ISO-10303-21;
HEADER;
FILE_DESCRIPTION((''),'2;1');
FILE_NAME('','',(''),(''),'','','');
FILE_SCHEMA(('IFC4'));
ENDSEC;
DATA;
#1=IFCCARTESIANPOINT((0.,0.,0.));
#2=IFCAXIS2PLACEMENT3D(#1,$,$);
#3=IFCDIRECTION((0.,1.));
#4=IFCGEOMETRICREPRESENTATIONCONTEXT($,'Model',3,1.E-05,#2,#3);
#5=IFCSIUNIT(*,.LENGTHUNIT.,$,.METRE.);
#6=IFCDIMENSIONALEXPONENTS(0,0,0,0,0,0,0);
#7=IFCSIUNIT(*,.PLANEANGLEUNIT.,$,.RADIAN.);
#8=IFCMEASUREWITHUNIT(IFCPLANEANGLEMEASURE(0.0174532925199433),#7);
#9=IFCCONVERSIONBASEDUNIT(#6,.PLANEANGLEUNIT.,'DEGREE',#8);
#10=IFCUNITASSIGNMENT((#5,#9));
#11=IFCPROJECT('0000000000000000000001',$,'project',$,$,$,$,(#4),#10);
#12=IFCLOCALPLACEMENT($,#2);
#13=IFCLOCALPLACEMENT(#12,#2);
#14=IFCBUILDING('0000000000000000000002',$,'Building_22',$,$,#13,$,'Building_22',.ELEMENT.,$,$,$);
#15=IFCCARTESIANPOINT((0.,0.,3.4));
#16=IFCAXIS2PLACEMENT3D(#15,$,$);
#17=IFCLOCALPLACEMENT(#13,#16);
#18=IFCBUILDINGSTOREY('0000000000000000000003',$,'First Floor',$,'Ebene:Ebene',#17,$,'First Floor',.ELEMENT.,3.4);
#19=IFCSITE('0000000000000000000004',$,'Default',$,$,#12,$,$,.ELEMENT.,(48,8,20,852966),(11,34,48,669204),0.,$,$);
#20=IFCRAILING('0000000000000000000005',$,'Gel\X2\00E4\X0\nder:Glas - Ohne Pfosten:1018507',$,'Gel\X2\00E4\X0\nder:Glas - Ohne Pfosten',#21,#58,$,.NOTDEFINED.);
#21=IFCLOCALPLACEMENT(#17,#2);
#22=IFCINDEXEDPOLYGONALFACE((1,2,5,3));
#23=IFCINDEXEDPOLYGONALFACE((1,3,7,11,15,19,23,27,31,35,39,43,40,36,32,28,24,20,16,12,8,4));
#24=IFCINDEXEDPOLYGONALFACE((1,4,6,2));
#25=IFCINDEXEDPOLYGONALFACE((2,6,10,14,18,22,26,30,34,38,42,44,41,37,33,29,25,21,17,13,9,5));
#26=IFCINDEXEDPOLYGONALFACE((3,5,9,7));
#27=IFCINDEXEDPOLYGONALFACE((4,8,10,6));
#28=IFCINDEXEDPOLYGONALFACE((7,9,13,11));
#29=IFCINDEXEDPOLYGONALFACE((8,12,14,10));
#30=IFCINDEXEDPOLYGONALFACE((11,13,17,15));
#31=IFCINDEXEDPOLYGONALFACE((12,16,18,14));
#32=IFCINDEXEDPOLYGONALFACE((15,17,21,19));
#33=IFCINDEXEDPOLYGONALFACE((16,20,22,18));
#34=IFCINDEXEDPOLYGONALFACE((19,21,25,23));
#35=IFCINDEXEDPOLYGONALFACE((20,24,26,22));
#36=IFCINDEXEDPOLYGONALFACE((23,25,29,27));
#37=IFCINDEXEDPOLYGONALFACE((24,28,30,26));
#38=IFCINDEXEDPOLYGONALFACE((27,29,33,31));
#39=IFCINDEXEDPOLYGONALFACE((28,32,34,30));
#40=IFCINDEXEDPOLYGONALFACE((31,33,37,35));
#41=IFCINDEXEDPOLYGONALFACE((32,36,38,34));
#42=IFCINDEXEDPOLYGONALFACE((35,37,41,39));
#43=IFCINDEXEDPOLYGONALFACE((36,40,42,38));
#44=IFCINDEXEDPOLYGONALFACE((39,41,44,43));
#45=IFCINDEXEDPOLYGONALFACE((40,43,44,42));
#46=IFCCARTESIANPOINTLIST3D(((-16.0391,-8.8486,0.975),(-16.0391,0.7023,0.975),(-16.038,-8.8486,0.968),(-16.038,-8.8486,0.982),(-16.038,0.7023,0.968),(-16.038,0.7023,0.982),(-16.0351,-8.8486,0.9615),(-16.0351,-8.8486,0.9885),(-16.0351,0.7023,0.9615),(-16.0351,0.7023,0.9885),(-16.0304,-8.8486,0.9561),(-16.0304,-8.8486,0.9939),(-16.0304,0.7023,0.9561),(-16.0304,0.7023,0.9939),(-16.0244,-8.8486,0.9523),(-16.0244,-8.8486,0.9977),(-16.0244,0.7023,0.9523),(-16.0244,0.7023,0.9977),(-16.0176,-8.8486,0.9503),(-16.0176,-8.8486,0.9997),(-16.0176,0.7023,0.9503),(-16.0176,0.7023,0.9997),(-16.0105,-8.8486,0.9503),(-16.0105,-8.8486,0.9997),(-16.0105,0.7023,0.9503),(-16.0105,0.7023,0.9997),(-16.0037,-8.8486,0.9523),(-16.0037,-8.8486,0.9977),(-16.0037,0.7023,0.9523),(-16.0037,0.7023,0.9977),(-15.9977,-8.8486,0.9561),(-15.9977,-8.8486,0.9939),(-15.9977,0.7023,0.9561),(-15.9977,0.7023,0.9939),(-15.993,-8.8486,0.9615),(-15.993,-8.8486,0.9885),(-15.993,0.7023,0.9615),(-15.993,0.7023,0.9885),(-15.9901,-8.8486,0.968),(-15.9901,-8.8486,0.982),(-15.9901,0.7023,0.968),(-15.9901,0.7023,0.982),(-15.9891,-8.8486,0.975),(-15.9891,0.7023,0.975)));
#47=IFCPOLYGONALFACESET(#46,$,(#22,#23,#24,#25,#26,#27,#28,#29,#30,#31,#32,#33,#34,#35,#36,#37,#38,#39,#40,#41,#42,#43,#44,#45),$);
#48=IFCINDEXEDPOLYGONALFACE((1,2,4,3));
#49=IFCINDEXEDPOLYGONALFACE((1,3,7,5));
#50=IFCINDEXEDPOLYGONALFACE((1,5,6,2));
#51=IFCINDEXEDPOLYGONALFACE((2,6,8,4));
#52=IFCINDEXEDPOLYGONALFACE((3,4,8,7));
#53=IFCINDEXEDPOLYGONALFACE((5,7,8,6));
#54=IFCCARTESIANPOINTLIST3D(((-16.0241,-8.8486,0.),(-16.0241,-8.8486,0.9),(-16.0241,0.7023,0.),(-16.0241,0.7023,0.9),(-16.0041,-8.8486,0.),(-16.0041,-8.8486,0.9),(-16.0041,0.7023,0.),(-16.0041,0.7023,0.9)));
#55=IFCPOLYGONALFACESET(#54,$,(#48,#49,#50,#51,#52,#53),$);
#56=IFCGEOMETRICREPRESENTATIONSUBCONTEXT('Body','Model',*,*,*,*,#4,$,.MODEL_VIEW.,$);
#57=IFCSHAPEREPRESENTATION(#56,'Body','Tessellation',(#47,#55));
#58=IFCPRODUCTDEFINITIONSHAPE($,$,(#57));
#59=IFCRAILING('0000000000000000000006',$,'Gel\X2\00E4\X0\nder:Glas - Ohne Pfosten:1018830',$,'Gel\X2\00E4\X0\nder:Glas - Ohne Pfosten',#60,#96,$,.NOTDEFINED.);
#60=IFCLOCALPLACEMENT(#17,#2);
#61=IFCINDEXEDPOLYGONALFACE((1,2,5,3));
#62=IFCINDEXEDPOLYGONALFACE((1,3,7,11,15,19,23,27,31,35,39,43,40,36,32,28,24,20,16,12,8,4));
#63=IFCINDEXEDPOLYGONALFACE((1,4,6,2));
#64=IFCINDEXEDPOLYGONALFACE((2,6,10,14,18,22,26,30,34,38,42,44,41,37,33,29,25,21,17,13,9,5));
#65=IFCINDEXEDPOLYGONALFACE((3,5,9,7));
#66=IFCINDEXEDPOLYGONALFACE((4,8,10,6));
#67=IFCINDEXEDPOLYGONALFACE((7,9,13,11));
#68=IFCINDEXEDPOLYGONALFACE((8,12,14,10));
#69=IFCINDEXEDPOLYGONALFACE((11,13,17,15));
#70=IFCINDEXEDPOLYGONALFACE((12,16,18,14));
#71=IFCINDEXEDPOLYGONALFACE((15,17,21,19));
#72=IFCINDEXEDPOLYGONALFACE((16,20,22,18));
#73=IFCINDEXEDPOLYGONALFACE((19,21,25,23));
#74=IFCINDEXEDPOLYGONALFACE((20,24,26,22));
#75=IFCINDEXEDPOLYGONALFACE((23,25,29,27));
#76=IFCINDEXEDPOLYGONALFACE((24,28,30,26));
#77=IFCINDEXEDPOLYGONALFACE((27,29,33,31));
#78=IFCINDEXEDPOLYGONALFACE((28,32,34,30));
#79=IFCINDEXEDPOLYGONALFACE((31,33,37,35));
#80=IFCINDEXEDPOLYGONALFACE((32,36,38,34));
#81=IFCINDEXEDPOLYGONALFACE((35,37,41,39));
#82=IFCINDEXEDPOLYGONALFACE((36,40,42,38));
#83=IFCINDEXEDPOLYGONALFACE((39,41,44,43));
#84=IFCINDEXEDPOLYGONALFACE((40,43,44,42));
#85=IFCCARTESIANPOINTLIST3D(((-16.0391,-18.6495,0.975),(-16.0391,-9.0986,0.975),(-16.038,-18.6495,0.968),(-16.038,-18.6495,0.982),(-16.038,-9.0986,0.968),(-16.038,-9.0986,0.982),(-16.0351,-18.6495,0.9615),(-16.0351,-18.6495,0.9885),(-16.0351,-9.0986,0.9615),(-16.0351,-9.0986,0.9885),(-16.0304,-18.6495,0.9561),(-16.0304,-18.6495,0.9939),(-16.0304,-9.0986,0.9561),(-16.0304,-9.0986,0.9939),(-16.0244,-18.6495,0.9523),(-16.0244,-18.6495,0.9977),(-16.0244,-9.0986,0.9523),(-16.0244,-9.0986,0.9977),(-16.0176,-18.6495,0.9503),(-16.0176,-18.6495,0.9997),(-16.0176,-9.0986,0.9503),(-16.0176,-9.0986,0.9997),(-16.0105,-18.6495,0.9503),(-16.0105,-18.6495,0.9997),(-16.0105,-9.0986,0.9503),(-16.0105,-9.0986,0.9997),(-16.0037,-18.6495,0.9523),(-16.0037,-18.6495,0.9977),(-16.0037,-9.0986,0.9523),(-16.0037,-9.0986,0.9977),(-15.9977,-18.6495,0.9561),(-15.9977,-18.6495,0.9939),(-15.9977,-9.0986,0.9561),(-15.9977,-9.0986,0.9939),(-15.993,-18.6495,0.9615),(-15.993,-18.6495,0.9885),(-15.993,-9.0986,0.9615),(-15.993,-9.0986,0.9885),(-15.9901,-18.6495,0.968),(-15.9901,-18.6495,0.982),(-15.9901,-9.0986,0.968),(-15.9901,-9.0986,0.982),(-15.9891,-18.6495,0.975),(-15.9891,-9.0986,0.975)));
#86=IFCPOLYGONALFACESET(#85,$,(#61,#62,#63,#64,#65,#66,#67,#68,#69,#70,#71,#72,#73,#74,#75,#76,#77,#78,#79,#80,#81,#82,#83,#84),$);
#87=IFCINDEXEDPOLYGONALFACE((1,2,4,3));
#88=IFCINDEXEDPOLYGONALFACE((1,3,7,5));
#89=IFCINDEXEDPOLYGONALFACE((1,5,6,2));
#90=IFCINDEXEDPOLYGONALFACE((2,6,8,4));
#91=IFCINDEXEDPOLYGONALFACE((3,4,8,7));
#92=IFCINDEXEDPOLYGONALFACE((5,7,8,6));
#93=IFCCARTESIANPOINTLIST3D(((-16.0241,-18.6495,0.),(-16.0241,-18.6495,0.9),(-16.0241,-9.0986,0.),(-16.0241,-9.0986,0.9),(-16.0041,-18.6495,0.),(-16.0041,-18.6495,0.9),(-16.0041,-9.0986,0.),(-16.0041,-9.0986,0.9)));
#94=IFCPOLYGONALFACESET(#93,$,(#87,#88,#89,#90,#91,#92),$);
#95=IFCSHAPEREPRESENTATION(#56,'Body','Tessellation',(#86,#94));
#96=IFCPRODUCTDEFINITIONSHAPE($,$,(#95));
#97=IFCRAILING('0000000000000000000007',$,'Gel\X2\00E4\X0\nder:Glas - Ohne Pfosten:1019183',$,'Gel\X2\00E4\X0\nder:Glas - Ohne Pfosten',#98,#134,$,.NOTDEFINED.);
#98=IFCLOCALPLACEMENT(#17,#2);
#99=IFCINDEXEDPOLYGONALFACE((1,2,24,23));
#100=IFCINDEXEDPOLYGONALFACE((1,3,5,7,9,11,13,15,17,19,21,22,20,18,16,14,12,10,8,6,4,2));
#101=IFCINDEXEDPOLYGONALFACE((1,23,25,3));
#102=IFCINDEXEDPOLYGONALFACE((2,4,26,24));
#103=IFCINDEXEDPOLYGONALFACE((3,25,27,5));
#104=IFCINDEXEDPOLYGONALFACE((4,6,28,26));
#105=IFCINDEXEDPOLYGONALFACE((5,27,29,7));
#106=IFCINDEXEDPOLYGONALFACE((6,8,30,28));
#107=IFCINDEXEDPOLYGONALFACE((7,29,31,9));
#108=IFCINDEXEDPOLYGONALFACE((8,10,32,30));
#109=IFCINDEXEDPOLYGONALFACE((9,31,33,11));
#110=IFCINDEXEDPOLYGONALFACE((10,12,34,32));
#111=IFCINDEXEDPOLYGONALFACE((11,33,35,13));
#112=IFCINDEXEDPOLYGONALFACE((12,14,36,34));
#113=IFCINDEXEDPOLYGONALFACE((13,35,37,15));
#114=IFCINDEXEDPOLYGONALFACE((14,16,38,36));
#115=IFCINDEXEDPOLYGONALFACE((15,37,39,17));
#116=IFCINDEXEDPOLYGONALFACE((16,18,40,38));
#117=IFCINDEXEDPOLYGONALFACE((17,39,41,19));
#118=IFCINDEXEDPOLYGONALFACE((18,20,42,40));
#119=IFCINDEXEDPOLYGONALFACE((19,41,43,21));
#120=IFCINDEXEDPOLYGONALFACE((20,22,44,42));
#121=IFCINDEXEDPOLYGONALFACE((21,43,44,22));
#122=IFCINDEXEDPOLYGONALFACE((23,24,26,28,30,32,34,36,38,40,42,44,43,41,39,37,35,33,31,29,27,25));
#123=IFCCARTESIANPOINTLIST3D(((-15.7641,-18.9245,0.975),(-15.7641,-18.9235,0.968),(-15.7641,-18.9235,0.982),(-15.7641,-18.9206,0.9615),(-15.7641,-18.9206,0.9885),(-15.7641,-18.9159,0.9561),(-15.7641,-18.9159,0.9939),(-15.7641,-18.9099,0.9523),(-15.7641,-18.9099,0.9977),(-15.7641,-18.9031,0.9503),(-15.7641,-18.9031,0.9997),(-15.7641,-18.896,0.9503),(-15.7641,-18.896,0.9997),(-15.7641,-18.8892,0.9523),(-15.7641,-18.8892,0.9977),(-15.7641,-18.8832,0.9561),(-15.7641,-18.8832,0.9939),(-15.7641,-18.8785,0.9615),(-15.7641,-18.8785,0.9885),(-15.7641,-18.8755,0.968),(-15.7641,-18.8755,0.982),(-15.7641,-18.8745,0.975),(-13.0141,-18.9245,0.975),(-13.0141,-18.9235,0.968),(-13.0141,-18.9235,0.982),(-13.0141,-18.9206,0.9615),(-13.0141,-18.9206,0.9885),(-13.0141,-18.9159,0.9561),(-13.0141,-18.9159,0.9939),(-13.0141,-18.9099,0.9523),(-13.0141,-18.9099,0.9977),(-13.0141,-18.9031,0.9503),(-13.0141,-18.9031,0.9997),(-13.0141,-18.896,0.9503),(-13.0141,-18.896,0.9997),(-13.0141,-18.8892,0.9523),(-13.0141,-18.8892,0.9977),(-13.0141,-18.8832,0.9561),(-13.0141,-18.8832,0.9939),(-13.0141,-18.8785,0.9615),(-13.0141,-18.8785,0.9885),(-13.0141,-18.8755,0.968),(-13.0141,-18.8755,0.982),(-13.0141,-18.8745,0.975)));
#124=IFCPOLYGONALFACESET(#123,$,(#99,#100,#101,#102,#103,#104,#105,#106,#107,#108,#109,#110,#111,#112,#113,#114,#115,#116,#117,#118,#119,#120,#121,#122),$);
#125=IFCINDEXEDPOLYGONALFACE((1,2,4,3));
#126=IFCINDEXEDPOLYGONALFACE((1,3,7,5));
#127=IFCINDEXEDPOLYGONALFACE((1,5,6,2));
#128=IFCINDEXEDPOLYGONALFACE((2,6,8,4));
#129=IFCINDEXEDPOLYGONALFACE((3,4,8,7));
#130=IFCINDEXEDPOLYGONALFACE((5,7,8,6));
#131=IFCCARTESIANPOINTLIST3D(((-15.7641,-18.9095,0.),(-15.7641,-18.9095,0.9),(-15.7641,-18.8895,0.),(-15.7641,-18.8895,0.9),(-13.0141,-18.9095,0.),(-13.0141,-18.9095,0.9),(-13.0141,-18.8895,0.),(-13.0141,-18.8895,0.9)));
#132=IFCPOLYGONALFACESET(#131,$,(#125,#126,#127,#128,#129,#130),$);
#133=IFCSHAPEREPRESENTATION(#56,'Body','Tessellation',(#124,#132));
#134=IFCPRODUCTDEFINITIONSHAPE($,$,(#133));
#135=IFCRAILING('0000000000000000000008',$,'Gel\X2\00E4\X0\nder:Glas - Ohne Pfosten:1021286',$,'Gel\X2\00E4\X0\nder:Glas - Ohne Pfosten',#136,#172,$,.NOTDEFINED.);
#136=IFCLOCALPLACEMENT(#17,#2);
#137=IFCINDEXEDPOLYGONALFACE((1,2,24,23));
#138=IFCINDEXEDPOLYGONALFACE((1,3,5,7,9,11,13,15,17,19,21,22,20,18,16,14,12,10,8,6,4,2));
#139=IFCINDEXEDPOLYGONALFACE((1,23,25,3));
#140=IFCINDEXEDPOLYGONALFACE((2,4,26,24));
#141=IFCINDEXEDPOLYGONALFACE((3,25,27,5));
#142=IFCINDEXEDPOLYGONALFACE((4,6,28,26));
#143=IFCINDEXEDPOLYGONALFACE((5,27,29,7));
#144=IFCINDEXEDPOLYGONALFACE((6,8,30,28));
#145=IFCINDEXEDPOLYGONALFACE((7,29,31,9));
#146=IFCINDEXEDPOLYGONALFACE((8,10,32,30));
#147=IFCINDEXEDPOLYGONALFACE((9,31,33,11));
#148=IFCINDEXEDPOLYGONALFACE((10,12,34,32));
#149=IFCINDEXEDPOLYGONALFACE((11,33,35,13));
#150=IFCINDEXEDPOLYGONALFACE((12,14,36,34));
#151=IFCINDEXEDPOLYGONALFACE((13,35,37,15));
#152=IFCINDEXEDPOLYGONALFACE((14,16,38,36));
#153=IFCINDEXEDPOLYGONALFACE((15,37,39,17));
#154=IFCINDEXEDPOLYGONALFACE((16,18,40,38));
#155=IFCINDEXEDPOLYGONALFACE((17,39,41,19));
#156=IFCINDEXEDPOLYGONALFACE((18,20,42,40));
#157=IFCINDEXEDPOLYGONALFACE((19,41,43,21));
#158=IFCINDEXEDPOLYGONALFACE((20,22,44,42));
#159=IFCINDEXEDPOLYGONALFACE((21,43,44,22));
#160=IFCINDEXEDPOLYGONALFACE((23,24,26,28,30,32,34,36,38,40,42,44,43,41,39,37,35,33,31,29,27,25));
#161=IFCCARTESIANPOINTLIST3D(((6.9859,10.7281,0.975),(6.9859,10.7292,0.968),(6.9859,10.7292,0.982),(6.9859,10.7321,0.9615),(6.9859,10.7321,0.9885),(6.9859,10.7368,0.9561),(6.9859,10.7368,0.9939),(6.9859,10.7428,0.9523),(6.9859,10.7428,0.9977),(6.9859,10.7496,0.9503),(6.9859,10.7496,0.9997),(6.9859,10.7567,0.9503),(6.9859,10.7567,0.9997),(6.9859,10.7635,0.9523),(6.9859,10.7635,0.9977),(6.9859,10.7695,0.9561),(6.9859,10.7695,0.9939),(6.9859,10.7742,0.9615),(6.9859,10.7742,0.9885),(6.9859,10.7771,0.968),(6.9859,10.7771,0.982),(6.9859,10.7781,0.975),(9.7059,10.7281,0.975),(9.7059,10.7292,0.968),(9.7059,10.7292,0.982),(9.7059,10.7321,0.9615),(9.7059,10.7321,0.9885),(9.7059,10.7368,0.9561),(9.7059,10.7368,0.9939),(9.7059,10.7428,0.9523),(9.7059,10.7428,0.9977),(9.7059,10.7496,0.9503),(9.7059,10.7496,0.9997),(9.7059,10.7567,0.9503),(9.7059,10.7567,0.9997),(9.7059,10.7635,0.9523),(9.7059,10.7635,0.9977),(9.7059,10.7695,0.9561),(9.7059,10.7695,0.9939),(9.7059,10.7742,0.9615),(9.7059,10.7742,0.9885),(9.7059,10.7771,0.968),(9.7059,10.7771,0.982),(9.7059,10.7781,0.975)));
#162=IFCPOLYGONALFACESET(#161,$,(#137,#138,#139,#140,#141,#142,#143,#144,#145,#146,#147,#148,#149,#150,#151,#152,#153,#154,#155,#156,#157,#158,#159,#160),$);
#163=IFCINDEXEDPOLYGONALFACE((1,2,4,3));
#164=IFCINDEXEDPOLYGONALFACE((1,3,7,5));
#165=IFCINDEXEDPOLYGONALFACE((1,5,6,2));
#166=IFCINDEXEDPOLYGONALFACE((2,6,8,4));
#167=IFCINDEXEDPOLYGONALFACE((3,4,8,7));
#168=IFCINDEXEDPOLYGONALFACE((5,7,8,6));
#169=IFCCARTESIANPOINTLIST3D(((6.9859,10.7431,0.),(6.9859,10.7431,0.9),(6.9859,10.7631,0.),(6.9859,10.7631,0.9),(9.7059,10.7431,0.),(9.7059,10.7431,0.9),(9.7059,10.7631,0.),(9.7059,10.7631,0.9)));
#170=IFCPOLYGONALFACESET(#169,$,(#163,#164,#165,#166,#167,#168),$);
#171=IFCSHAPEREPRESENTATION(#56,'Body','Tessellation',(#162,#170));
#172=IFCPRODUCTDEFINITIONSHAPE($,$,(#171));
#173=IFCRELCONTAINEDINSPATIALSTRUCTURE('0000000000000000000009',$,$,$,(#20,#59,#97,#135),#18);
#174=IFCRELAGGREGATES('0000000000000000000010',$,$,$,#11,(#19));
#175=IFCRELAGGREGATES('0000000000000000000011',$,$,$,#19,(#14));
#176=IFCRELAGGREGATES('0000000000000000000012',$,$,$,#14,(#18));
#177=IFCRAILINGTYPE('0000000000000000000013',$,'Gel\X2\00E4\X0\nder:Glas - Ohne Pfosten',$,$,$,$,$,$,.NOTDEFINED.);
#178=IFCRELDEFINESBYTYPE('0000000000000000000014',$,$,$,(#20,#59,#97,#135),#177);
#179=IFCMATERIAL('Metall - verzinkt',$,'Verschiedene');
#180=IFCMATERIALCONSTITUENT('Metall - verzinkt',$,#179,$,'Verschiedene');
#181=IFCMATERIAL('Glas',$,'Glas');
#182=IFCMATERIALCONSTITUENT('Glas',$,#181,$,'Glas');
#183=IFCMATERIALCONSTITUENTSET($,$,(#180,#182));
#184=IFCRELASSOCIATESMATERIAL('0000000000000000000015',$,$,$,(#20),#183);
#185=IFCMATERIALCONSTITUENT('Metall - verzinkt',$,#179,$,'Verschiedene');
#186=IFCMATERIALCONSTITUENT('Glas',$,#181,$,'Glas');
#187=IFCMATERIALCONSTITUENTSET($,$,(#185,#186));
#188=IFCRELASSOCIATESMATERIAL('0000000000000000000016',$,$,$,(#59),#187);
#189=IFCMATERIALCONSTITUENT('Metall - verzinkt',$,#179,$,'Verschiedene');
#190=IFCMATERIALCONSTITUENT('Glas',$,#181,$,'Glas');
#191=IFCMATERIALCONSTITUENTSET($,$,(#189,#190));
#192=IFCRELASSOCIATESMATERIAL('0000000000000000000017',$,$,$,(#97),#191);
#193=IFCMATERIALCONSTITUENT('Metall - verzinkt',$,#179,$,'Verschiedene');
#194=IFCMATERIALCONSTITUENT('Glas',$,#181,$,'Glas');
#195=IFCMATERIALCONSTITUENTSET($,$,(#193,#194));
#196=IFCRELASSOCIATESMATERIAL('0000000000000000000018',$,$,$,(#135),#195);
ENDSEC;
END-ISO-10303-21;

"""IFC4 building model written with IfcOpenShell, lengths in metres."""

from ifc_helpers import new_model, entity, si_unit, converted_unit, direction, frame, origin, place, context, subcontext, project, spatial, arc, indexed_curve, outline, extrude, material, constituent, constituent_set, type_object, element, save


model = new_model("IFC4")

# Units and contexts
model_context = context("Model", 3, precision=1e-05, world=origin(), true_north=direction((0.0, 1.0)))
body_context = subcontext(model_context, "Body", "Model", "MODEL_VIEW")
ifc_project = project(units=[si_unit("LENGTHUNIT", "METRE"), converted_unit("PLANEANGLEUNIT", "DEGREE", entity("IfcPlaneAngleMeasure", 0.0174532925199433), si_unit("PLANEANGLEUNIT", "RADIAN"), dimensions=[0, 0, 0, 0, 0, 0, 0])], contexts=[model_context])

# Site, building, storey
site_placement = place(None, origin())
site = spatial("IfcSite", under=ifc_project, at=site_placement, Name="Default", CompositionType="ELEMENT", RefLatitude=(48, 8, 20, 852966), RefLongitude=(11, 34, 48, 669204), RefElevation=0.0)
building_placement = place(site_placement, origin())
building = spatial("IfcBuilding", under=site, at=building_placement, Name="Building_22", LongName="Building_22", CompositionType="ELEMENT")
storey_placement = place(building_placement, frame((0.0, 0.0, 3.4)))
storey = spatial("IfcBuildingStorey", under=building, at=storey_placement, Name="First Floor", ObjectType="Ebene:Ebene", LongName="First Floor", CompositionType="ELEMENT", Elevation=3.4)

# Shared definitions
ifc_material_1 = material(Name="Glas", Category="Glas")

# Railings
ifc_material_2 = material(Name="Metall - verzinkt", Category="Verschiedene")
ifc_constituent_1 = constituent(ifc_material_2, Name="Metall - verzinkt", Category="Verschiedene")
ifc_constituent_2 = constituent(ifc_material_1, Name="Glas", Category="Glas")
ifc_constituent_set_1 = constituent_set(constituents=[ifc_constituent_1, ifc_constituent_2])
railing_type = type_object("IfcRailingType", Name="Geländer:Glas - Ohne Pfosten", PredefinedType="NOTDEFINED")
railing_1_placement = place(storey_placement, origin())
element("IfcRailing", 1, at=railing_1_placement, inside=storey, type_object=railing_type, material=ifc_constituent_set_1, Name="Geländer:Glas - Ohne Pfosten:1018507", ObjectType="Geländer:Glas - Ohne Pfosten", PredefinedType="NOTDEFINED", context=body_context, shape_type="SweptSolid", body=[
    extrude(outline(indexed_curve([(-0.025, 0.0), (0.0, -0.025), (0.025, 0.0), (0.0, 0.025)], segments=[arc(1, 2, 3), arc(3, 4, 1)], self_intersect=False)), frame((-16.0141, -8.8486, 0.975), z_axis=(0.0, 1.0, 0.0), x_axis=(-1.0, 0.0, 0.0)), (0.0, 0.0, 1.0), 9.5509),
    extrude(outline(indexed_curve([(-4.7754, -0.01), (4.7754, -0.01), (4.7754, 0.01), (-4.7754, 0.01), (-4.7754, -0.01)], self_intersect=False)), frame((-16.0141, -4.0732, 0.0), z_axis=(0.0, 0.0, 1.0), x_axis=(0.0, -1.0, 0.0)), (0.0, 0.0, 1.0), 0.9),
])
ifc_constituent_3 = constituent(ifc_material_2, Name="Metall - verzinkt", Category="Verschiedene")
ifc_constituent_4 = constituent(ifc_material_1, Name="Glas", Category="Glas")
ifc_constituent_set_2 = constituent_set(constituents=[ifc_constituent_3, ifc_constituent_4])
railing_2_placement = place(storey_placement, origin())
element("IfcRailing", 2, at=railing_2_placement, inside=storey, type_object=railing_type, material=ifc_constituent_set_2, Name="Geländer:Glas - Ohne Pfosten:1018830", ObjectType="Geländer:Glas - Ohne Pfosten", PredefinedType="NOTDEFINED", context=body_context, shape_type="SweptSolid", body=[
    extrude(outline(indexed_curve([(-0.025, 0.0), (0.0, -0.025), (0.025, 0.0), (0.0, 0.025)], segments=[arc(1, 2, 3), arc(3, 4, 1)], self_intersect=False)), frame((-16.0141, -18.6495, 0.975), z_axis=(0.0, 1.0, 0.0), x_axis=(-1.0, 0.0, 0.0)), (0.0, 0.0, 1.0), 9.5509),
    extrude(outline(indexed_curve([(-4.7754, -0.01), (4.7754, -0.01), (4.7754, 0.01), (-4.7754, 0.01), (-4.7754, -0.01)], self_intersect=False)), frame((-16.0141, -13.8741, 0.0), z_axis=(0.0, 0.0, 1.0), x_axis=(0.0, -1.0, 0.0)), (0.0, 0.0, 1.0), 0.9),
])
ifc_constituent_5 = constituent(ifc_material_2, Name="Metall - verzinkt", Category="Verschiedene")
ifc_constituent_6 = constituent(ifc_material_1, Name="Glas", Category="Glas")
ifc_constituent_set_3 = constituent_set(constituents=[ifc_constituent_5, ifc_constituent_6])
railing_3_placement = place(storey_placement, origin())
element("IfcRailing", 3, at=railing_3_placement, inside=storey, type_object=railing_type, material=ifc_constituent_set_3, Name="Geländer:Glas - Ohne Pfosten:1019183", ObjectType="Geländer:Glas - Ohne Pfosten", PredefinedType="NOTDEFINED", context=body_context, shape_type="SweptSolid", body=[
    extrude(outline(indexed_curve([(-0.025, 0.0), (0.0, -0.025), (0.025, 0.0), (0.0, 0.025)], segments=[arc(1, 2, 3), arc(3, 4, 1)], self_intersect=False)), frame((-15.7641, -18.8995, 0.975), z_axis=(1.0, 0.0, 0.0), x_axis=(0.0, -1.0, 0.0)), (0.0, 0.0, 1.0), 2.75),
    extrude(outline(indexed_curve([(-1.375, -0.01), (1.375, -0.01), (1.375, 0.01), (-1.375, 0.01), (-1.375, -0.01)], self_intersect=False)), frame((-14.3891, -18.8995, 0.0)), (0.0, 0.0, 1.0), 0.9),
])
ifc_constituent_7 = constituent(ifc_material_2, Name="Metall - verzinkt", Category="Verschiedene")
ifc_constituent_8 = constituent(ifc_material_1, Name="Glas", Category="Glas")
ifc_constituent_set_4 = constituent_set(constituents=[ifc_constituent_7, ifc_constituent_8])
railing_4_placement = place(storey_placement, origin())
element("IfcRailing", 4, at=railing_4_placement, inside=storey, type_object=railing_type, material=ifc_constituent_set_4, Name="Geländer:Glas - Ohne Pfosten:1021286", ObjectType="Geländer:Glas - Ohne Pfosten", PredefinedType="NOTDEFINED", context=body_context, shape_type="SweptSolid", body=[
    extrude(outline(indexed_curve([(-0.025, 0.0), (0.0, -0.025), (0.025, 0.0), (0.0, 0.025)], segments=[arc(1, 2, 3), arc(3, 4, 1)], self_intersect=False)), frame((6.9859, 10.7531, 0.975), z_axis=(1.0, 0.0, 0.0), x_axis=(0.0, -1.0, 0.0)), (0.0, 0.0, 1.0), 2.72),
    extrude(outline(indexed_curve([(-1.36, -0.01), (1.36, -0.01), (1.36, 0.01), (-1.36, 0.01), (-1.36, -0.01)], self_intersect=False)), frame((8.3459, 10.7531, 0.0)), (0.0, 0.0, 1.0), 0.9),
])

save(model, "model.ifc")
